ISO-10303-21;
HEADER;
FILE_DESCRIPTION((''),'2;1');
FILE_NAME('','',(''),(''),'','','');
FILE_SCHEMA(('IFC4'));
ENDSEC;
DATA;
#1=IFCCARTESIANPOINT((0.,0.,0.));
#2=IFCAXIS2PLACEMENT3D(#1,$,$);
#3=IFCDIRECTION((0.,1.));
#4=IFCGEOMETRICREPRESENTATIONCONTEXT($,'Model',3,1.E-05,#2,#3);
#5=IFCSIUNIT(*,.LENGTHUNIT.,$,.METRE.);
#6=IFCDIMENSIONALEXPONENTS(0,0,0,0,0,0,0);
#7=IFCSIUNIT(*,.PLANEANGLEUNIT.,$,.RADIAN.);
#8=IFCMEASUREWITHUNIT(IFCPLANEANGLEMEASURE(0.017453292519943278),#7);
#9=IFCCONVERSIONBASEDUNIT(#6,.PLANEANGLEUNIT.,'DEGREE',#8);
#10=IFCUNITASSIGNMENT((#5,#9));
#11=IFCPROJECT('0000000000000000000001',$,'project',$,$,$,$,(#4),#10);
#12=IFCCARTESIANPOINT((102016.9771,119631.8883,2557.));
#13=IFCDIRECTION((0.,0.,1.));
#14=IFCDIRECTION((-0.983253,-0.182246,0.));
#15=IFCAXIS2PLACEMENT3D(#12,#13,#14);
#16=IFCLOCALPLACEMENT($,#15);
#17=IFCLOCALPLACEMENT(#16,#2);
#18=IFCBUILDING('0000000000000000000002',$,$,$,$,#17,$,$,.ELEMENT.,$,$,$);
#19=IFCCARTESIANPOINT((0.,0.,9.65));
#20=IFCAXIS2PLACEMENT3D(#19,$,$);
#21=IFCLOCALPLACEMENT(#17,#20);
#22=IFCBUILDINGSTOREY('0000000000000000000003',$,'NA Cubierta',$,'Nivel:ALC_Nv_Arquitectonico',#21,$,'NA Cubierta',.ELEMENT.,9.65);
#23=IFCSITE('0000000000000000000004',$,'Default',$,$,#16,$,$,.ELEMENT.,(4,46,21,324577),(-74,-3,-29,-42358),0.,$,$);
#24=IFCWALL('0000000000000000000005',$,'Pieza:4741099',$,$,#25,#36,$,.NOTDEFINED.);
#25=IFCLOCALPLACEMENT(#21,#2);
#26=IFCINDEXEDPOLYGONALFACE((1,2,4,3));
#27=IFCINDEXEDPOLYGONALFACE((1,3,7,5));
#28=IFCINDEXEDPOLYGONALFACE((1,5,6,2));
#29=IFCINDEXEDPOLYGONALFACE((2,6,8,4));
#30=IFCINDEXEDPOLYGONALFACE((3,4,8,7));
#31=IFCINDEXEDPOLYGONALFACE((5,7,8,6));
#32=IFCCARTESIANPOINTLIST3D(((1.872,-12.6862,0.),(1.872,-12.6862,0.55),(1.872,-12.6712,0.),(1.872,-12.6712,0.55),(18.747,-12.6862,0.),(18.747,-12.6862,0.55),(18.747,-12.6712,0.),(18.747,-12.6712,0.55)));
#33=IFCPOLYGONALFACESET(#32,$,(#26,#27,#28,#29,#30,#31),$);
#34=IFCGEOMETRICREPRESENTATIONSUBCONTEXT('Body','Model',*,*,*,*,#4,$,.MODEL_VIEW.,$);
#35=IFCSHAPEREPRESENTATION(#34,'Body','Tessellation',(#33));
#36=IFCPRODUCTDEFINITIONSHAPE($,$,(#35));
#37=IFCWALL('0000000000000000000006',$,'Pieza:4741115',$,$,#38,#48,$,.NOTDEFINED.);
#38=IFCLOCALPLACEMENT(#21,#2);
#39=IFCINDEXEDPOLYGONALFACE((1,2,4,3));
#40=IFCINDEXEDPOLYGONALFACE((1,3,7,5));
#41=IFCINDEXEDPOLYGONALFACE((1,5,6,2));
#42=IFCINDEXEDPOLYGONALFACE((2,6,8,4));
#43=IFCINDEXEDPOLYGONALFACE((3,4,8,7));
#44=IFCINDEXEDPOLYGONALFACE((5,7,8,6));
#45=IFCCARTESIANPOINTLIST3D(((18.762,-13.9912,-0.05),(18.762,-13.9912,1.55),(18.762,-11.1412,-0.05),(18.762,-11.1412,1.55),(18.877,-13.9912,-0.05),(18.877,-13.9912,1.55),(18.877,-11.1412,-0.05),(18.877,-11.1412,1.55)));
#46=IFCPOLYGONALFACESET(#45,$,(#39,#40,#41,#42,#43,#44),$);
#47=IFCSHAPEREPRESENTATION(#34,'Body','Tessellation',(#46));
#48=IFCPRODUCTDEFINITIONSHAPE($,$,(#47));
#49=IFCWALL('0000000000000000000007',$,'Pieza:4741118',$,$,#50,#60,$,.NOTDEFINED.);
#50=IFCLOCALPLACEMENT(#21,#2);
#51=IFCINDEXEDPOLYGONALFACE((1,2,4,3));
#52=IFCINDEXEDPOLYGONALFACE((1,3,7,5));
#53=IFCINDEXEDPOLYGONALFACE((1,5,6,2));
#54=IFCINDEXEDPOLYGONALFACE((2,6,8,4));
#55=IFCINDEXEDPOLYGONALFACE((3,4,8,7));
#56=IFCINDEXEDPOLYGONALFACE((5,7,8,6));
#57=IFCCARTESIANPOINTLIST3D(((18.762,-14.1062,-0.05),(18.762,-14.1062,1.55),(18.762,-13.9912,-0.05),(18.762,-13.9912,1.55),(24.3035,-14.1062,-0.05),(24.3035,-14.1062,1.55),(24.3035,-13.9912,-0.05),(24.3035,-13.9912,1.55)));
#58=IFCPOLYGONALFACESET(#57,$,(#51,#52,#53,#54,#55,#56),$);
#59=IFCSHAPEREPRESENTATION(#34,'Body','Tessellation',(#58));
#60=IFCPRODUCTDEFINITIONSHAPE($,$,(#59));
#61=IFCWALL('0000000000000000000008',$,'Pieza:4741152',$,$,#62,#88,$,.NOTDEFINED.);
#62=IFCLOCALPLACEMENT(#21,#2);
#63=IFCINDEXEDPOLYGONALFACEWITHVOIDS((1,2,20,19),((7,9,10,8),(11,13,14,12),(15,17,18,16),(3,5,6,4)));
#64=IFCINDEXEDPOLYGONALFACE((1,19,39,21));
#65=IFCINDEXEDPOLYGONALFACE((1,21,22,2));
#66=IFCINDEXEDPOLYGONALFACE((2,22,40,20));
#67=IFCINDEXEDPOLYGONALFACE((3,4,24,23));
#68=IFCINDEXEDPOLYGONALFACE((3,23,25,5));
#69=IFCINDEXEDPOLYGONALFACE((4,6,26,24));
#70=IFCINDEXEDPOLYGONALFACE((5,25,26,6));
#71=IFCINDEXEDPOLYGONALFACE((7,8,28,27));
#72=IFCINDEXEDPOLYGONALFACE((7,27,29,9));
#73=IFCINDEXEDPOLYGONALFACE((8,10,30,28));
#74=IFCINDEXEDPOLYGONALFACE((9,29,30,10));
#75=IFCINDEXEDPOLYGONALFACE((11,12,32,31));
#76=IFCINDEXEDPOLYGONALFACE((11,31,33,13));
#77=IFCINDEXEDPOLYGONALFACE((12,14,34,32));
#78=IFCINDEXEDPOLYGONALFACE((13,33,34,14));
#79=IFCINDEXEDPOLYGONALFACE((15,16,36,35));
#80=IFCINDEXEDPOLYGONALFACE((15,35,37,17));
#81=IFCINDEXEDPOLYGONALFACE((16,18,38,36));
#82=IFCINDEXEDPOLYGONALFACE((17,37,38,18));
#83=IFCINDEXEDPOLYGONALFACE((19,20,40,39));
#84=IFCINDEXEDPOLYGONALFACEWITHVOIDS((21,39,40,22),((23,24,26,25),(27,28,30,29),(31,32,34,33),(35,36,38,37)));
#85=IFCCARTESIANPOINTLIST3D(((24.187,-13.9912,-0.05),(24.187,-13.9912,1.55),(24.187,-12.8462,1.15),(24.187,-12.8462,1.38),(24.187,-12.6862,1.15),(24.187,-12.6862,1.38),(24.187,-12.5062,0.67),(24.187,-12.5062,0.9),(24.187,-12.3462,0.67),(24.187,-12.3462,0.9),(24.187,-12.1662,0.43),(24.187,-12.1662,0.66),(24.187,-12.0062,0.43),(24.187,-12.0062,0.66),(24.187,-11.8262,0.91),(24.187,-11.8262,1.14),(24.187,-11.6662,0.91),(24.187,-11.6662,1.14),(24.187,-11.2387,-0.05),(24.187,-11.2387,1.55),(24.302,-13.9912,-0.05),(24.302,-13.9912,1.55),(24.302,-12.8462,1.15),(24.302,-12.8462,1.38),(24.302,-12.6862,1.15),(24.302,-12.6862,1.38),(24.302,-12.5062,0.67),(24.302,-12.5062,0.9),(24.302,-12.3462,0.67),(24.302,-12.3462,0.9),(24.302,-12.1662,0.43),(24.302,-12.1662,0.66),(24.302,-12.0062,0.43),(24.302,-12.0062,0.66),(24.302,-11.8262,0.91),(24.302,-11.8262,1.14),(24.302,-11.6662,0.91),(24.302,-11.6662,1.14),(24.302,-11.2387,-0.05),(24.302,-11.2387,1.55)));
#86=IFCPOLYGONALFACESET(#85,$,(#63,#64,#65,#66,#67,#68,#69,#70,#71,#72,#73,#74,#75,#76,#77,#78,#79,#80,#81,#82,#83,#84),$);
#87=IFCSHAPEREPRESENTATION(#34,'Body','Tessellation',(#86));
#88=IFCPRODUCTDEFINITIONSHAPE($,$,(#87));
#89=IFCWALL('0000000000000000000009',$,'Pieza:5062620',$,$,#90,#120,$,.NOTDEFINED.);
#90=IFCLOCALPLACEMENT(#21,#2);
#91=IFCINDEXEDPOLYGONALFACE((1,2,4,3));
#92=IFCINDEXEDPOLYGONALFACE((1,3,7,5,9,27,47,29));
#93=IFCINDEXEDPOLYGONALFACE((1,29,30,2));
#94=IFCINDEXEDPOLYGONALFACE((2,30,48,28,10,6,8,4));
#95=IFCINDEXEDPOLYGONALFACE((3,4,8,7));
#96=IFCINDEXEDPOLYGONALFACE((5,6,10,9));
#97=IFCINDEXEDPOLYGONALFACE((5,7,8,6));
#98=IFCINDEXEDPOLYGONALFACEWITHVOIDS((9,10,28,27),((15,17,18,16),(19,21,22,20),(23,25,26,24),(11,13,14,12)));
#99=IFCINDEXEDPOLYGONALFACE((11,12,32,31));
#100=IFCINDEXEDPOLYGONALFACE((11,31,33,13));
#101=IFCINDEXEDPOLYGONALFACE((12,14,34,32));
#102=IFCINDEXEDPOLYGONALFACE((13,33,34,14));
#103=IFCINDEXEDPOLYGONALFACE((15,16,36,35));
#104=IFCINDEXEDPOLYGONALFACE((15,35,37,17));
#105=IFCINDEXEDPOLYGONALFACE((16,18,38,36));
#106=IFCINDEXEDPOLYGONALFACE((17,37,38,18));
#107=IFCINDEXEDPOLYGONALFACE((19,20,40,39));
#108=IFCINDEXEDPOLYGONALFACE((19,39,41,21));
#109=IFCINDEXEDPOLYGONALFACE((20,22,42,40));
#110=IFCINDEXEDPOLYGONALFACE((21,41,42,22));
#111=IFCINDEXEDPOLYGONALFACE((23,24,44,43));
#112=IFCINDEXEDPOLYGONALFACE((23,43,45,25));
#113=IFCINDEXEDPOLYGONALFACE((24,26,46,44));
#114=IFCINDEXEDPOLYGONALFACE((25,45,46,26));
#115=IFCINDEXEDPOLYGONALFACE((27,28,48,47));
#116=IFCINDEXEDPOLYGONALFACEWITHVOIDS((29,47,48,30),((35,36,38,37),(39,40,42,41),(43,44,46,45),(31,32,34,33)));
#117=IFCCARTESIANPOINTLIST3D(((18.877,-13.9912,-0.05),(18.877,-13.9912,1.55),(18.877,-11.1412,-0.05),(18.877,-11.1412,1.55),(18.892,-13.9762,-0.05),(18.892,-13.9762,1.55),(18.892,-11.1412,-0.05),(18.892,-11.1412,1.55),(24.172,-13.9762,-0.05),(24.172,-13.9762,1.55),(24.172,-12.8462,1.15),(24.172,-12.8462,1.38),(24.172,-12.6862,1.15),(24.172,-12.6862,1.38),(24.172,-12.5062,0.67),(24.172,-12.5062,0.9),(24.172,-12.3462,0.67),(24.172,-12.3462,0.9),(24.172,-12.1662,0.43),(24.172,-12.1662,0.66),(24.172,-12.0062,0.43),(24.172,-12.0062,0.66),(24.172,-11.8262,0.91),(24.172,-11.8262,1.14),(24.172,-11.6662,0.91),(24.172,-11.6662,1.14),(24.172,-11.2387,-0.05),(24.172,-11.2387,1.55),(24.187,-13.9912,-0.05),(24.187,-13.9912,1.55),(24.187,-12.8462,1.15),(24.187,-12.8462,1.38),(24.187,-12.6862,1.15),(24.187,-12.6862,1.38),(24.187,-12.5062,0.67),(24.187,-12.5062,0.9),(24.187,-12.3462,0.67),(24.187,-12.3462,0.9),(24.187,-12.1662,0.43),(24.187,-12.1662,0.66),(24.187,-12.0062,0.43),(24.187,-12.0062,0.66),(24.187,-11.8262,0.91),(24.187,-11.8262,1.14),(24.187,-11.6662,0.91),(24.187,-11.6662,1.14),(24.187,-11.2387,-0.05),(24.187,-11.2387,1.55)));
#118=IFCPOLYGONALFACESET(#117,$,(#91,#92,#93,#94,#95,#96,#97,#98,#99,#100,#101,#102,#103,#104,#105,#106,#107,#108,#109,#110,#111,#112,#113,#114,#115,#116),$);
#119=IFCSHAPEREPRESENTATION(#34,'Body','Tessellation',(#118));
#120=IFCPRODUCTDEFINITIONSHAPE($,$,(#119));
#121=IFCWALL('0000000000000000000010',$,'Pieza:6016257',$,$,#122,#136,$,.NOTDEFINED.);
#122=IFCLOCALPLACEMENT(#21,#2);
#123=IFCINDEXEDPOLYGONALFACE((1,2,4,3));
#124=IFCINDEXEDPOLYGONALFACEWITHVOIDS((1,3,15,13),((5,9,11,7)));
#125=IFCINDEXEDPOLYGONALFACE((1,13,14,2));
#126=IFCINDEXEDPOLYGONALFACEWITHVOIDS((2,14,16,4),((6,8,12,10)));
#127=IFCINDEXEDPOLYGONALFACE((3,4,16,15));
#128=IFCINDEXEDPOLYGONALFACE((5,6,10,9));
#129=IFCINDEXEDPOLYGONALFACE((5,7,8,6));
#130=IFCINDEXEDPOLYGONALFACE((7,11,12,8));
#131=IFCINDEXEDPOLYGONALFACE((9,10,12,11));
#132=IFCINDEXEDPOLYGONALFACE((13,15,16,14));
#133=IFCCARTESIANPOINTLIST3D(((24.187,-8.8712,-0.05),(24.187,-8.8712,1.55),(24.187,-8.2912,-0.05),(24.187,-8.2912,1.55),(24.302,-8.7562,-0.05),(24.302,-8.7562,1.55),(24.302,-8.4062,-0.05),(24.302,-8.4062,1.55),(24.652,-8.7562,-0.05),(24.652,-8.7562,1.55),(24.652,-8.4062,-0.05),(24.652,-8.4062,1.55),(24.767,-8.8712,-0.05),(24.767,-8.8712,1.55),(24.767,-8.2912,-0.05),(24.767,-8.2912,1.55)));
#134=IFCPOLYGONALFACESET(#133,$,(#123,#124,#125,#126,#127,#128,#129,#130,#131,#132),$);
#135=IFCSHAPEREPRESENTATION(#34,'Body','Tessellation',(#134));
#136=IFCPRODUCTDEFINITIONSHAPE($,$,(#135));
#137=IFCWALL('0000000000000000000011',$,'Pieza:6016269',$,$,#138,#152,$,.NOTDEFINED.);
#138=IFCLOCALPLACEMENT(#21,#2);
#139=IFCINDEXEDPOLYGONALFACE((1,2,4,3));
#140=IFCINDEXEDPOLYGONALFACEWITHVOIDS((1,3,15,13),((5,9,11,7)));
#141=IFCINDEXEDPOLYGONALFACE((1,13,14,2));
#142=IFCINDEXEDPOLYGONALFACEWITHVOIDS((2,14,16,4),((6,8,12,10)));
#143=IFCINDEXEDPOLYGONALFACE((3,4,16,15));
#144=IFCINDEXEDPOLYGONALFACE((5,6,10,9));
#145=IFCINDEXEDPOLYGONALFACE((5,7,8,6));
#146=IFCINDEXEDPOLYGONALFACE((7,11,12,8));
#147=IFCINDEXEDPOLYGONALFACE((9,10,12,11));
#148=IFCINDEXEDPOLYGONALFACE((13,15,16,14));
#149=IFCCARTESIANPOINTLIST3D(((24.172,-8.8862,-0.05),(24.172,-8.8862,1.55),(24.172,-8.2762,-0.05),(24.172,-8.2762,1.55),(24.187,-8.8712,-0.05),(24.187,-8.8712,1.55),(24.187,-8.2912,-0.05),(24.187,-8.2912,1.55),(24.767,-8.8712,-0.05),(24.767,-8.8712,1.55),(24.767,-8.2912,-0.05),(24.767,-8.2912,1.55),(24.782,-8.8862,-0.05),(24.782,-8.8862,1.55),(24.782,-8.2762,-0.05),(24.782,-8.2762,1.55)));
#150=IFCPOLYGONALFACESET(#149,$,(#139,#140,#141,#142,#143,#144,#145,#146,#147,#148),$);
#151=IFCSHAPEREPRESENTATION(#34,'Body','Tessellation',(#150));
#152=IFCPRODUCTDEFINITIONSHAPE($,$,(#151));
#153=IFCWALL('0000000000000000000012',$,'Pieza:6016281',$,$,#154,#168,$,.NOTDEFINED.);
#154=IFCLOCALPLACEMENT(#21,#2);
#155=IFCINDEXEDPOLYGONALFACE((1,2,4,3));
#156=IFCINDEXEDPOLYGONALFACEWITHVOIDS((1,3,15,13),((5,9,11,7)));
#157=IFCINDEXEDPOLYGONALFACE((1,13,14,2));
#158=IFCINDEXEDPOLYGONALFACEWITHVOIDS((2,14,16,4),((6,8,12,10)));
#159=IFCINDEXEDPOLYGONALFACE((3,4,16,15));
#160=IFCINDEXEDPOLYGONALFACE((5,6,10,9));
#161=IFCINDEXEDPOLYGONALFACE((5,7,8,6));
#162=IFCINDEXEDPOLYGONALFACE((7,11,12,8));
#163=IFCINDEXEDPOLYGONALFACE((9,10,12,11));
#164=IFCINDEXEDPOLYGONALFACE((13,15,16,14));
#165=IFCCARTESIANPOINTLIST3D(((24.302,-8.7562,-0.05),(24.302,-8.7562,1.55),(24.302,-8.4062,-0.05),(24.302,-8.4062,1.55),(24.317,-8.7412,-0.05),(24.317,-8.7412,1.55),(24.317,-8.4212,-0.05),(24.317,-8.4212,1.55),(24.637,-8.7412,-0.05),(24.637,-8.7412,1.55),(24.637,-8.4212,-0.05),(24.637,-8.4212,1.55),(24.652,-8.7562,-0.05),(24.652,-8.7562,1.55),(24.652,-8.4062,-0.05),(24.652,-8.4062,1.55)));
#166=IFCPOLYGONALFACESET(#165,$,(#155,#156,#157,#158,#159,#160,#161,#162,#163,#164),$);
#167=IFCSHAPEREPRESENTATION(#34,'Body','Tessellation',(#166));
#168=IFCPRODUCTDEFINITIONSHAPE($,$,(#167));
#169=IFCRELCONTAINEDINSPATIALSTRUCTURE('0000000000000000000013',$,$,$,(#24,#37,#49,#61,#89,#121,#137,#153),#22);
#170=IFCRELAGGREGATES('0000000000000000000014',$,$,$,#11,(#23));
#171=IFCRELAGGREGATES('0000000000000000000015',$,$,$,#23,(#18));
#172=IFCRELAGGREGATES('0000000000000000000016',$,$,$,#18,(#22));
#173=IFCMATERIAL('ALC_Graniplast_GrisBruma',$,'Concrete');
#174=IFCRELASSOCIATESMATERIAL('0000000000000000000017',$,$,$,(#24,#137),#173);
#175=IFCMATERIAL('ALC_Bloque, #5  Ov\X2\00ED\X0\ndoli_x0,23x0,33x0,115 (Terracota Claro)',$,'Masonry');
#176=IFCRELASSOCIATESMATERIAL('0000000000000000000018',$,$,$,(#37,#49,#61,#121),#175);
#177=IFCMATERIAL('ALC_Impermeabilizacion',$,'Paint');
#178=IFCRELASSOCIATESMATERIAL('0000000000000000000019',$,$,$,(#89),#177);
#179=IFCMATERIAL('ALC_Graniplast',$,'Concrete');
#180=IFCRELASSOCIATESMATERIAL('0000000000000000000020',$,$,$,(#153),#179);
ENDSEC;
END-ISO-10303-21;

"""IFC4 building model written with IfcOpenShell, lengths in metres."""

from ifc_helpers import new_model, entity, si_unit, converted_unit, direction, frame, frame_2d, origin, origin_2d_with_axis, place, context, subcontext, project, spatial, polyline, rectangle, outline, extrude, boolean, material, element, save


model = new_model("IFC4")

# Units and contexts
model_context = context("Model", 3, precision=1e-05, world=origin(), true_north=direction((0.0, 1.0)))
body_context = subcontext(model_context, "Body", "Model", "MODEL_VIEW")
ifc_project = project(units=[si_unit("LENGTHUNIT", "METRE"), converted_unit("PLANEANGLEUNIT", "DEGREE", entity("IfcPlaneAngleMeasure", 0.017453292519943278), si_unit("PLANEANGLEUNIT", "RADIAN"), dimensions=[0, 0, 0, 0, 0, 0, 0])], contexts=[model_context])

# Site, building, storey
site_placement = place(None, frame((102016.9771, 119631.8883, 2557.0), z_axis=(0.0, 0.0, 1.0), x_axis=(-0.983253, -0.182246, 0.0)))
site = spatial("IfcSite", under=ifc_project, at=site_placement, Name="Default", CompositionType="ELEMENT", RefLatitude=(4, 46, 21, 324577), RefLongitude=(-74, -3, -29, -42358), RefElevation=0.0)
building_placement = place(site_placement, origin())
building = spatial("IfcBuilding", under=site, at=building_placement, CompositionType="ELEMENT")
storey_placement = place(building_placement, frame((0.0, 0.0, 9.65)))
storey = spatial("IfcBuildingStorey", under=building, at=storey_placement, Name="NA Cubierta", ObjectType="Nivel:ALC_Nv_Arquitectonico", LongName="NA Cubierta", CompositionType="ELEMENT", Elevation=9.65)

# Walls
ifc_material_1 = material(Name="ALC_Graniplast_GrisBruma", Category="Concrete")
wall_1_placement = place(storey_placement, frame((0.0, 0.0, -0.55)))
element("IfcWall", 1, at=wall_1_placement, inside=storey, material=ifc_material_1, Name="Pieza:4741099", PredefinedType="NOTDEFINED", context=body_context, shape_type="SweptSolid", body=[
    extrude(rectangle(XDim=0.015, YDim=16.875, at=frame_2d((0.0, 0.0), x_axis=(1.0, 0.0))), frame((10.3095, -12.6787, 0.55), z_axis=(0.0, 0.0, 1.0), x_axis=(0.0, -1.0, 0.0)), (0.0, 0.0, 1.0), 0.55),
])
ifc_material_2 = material(Name="ALC_Bloque, #5  Ovíndoli_x0,23x0,33x0,115 (Terracota Claro)", Category="Masonry")
wall_2_placement = place(storey_placement, frame((0.0, 0.0, -0.05)))
element("IfcWall", 2, at=wall_2_placement, inside=storey, material=ifc_material_2, Name="Pieza:4741115", PredefinedType="NOTDEFINED", context=body_context, shape_type="SweptSolid", body=[
    extrude(rectangle(XDim=2.85, YDim=0.115, at=frame_2d((0.0, 0.0), x_axis=(1.0, 0.0))), frame((18.8195, -12.5662, 0.0), z_axis=(0.0, 0.0, 1.0), x_axis=(0.0, -1.0, 0.0)), (0.0, 0.0, 1.0), 1.6),
])
wall_3_placement = place(storey_placement, frame((0.0, 0.0, -0.05)))
element("IfcWall", 3, at=wall_3_placement, inside=storey, material=ifc_material_2, Name="Pieza:4741118", PredefinedType="NOTDEFINED", context=body_context, shape_type="SweptSolid", body=[
    extrude(rectangle(XDim=0.115, YDim=5.5415, at=frame_2d((0.0, 0.0), x_axis=(1.0, 0.0))), frame((21.5328, -14.0487, 0.0), z_axis=(0.0, 0.0, 1.0), x_axis=(0.0, -1.0, 0.0)), (0.0, 0.0, 1.0), 1.6),
])
wall_4_placement = place(storey_placement, frame((0.0, 0.0, -0.05)))
element("IfcWall", 4, at=wall_4_placement, inside=storey, material=ifc_material_2, Name="Pieza:4741152", PredefinedType="NOTDEFINED", context=body_context, shape_type="SweptSolid", body=[
    boolean("DIFFERENCE", boolean("DIFFERENCE", boolean("DIFFERENCE", boolean("DIFFERENCE", extrude(rectangle(XDim=0.115, YDim=2.7525, at=frame_2d((0.0, 0.0), x_axis=(1.0, 0.0))), frame((24.2445, -12.6149, 0.0)), (0.0, 0.0, 1.0), 1.6), extrude(rectangle(XDim=0.23, YDim=0.16, at=frame_2d((0.0, 0.0), x_axis=(0.0, 1.0))), frame((24.187, -12.0862, 0.595), z_axis=(1.0, 0.0, 0.0), x_axis=(0.0, -1.0, 0.0)), (0.0, 0.0, 1.0), 0.115)), extrude(rectangle(XDim=0.23, YDim=0.16, at=frame_2d((0.0, 0.0), x_axis=(0.0, 1.0))), frame((24.187, -12.4262, 0.835), z_axis=(1.0, 0.0, 0.0), x_axis=(0.0, -1.0, 0.0)), (0.0, 0.0, 1.0), 0.115)), extrude(rectangle(XDim=0.23, YDim=0.16, at=frame_2d((0.0, 0.0), x_axis=(0.0, 1.0))), frame((24.187, -11.7462, 1.075), z_axis=(1.0, 0.0, 0.0), x_axis=(0.0, -1.0, 0.0)), (0.0, 0.0, 1.0), 0.115)), extrude(rectangle(XDim=0.23, YDim=0.16, at=frame_2d((0.0, 0.0), x_axis=(0.0, 1.0))), frame((24.187, -12.7662, 1.315), z_axis=(1.0, 0.0, 0.0), x_axis=(0.0, -1.0, 0.0)), (0.0, 0.0, 1.0), 0.115)),
])

# Wall, openings
ifc_material_3 = material(Name="ALC_Impermeabilizacion", Category="Paint")
wall_5_placement = place(storey_placement, frame((0.0, 0.0, -0.05)))
wall_5 = element("IfcWall", 5, at=wall_5_placement, inside=storey, material=ifc_material_3, Name="Pieza:5062620", PredefinedType="NOTDEFINED", context=body_context, shape_type="SweptSolid", body=[
    extrude(outline(polyline([(2.64, -1.4456), (2.655, -1.4456), (2.655, 1.4044), (-2.655, 1.4044), (-2.655, -1.3481), (-2.64, -1.3481), (-2.64, 1.3894), (2.64, 1.3894), (2.64, -1.4456)])), frame((21.532, -12.5868, 0.0), z_axis=(0.0, 0.0, 1.0), x_axis=(-1.0, 0.0, 0.0)), (0.0, 0.0, 1.0), 1.6),
])
opening_1_placement = place(storey_placement, frame((0.0, 0.0, -0.05)))
element("IfcOpeningElement", 6, at=opening_1_placement, cuts=wall_5, PredefinedType="OPENING", context=body_context, shape_type="SweptSolid", body=[
    extrude(rectangle(XDim=0.23, YDim=0.16, at=frame_2d((0.0, 0.0), x_axis=(0.0, 1.0))), frame((24.187, -11.7462, 1.075), z_axis=(-1.0, 0.0, 0.0), x_axis=(0.0, -1.0, 0.0)), (0.0, 0.0, 1.0), 0.015),
])
opening_2_placement = place(storey_placement, frame((0.0, 0.0, -0.05)))
element("IfcOpeningElement", 7, at=opening_2_placement, cuts=wall_5, PredefinedType="OPENING", context=body_context, shape_type="SweptSolid", body=[
    extrude(rectangle(XDim=0.23, YDim=0.16, at=frame_2d((0.0, 0.0), x_axis=(1.0, 0.0))), frame((24.187, -12.0862, 0.595), z_axis=(-1.0, 0.0, 0.0), x_axis=(0.0, 0.0, -1.0)), (0.0, 0.0, 1.0), 0.015),
])
opening_3_placement = place(storey_placement, frame((0.0, 0.0, -0.05)))
element("IfcOpeningElement", 8, at=opening_3_placement, cuts=wall_5, PredefinedType="OPENING", context=body_context, shape_type="SweptSolid", body=[
    extrude(rectangle(XDim=0.23, YDim=0.16, at=origin_2d_with_axis()), frame((24.187, -12.4262, 0.835), z_axis=(-1.0, 0.0, 0.0), x_axis=(0.0, 0.0, -1.0)), (0.0, 0.0, 1.0), 0.015),
])
opening_4_placement = place(storey_placement, frame((0.0, 0.0, -0.05)))
element("IfcOpeningElement", 9, at=opening_4_placement, cuts=wall_5, PredefinedType="OPENING", context=body_context, shape_type="SweptSolid", body=[
    extrude(rectangle(XDim=0.23, YDim=0.16, at=frame_2d((0.0, 0.0), x_axis=(1.0, 0.0))), frame((24.187, -12.7662, 1.315), z_axis=(-1.0, 0.0, 0.0), x_axis=(0.0, 0.0, -1.0)), (0.0, 0.0, 1.0), 0.015),
])

# Walls
wall_6_placement = place(storey_placement, frame((0.0, 0.0, -0.05)))
element("IfcWall", 10, at=wall_6_placement, inside=storey, material=ifc_material_2, Name="Pieza:6016257", PredefinedType="NOTDEFINED", context=body_context, shape_type="SweptSolid", body=[
    extrude(outline(polyline([(-0.29, -0.29), (0.29, -0.29), (0.29, 0.29), (-0.29, 0.29), (-0.29, -0.29)]), holes=[polyline([(-0.175, 0.175), (0.175, 0.175), (0.175, -0.175), (-0.175, -0.175), (-0.175, 0.175)])]), frame((24.477, -8.5812, 0.0), z_axis=(0.0, 0.0, 1.0), x_axis=(0.0, 1.0, 0.0)), (0.0, 0.0, 1.0), 1.6),
])
wall_7_placement = place(storey_placement, frame((0.0, 0.0, -0.05)))
element("IfcWall", 11, at=wall_7_placement, inside=storey, material=ifc_material_1, Name="Pieza:6016269", PredefinedType="NOTDEFINED", context=body_context, shape_type="SweptSolid", body=[
    extrude(outline(polyline([(-0.305, -0.305), (0.305, -0.305), (0.305, 0.305), (-0.305, 0.305), (-0.305, -0.305)]), holes=[polyline([(0.29, 0.29), (0.29, -0.29), (-0.29, -0.29), (-0.29, 0.29), (0.29, 0.29)])]), frame((24.477, -8.5812, 0.0)), (0.0, 0.0, 1.0), 1.6),
])
ifc_material_4 = material(Name="ALC_Graniplast", Category="Concrete")
wall_8_placement = place(storey_placement, frame((0.0, 0.0, -0.05)))
element("IfcWall", 12, at=wall_8_placement, inside=storey, material=ifc_material_4, Name="Pieza:6016281", PredefinedType="NOTDEFINED", context=body_context, shape_type="SweptSolid", body=[
    extrude(outline(polyline([(-0.175, -0.175), (0.175, -0.175), (0.175, 0.175), (-0.175, 0.175), (-0.175, -0.175)]), holes=[polyline([(0.16, 0.16), (0.16, -0.16), (-0.16, -0.16), (-0.16, 0.16), (0.16, 0.16)])]), frame((24.477, -8.5812, 0.0)), (0.0, 0.0, 1.0), 1.6),
])

save(model, "model.ifc")
